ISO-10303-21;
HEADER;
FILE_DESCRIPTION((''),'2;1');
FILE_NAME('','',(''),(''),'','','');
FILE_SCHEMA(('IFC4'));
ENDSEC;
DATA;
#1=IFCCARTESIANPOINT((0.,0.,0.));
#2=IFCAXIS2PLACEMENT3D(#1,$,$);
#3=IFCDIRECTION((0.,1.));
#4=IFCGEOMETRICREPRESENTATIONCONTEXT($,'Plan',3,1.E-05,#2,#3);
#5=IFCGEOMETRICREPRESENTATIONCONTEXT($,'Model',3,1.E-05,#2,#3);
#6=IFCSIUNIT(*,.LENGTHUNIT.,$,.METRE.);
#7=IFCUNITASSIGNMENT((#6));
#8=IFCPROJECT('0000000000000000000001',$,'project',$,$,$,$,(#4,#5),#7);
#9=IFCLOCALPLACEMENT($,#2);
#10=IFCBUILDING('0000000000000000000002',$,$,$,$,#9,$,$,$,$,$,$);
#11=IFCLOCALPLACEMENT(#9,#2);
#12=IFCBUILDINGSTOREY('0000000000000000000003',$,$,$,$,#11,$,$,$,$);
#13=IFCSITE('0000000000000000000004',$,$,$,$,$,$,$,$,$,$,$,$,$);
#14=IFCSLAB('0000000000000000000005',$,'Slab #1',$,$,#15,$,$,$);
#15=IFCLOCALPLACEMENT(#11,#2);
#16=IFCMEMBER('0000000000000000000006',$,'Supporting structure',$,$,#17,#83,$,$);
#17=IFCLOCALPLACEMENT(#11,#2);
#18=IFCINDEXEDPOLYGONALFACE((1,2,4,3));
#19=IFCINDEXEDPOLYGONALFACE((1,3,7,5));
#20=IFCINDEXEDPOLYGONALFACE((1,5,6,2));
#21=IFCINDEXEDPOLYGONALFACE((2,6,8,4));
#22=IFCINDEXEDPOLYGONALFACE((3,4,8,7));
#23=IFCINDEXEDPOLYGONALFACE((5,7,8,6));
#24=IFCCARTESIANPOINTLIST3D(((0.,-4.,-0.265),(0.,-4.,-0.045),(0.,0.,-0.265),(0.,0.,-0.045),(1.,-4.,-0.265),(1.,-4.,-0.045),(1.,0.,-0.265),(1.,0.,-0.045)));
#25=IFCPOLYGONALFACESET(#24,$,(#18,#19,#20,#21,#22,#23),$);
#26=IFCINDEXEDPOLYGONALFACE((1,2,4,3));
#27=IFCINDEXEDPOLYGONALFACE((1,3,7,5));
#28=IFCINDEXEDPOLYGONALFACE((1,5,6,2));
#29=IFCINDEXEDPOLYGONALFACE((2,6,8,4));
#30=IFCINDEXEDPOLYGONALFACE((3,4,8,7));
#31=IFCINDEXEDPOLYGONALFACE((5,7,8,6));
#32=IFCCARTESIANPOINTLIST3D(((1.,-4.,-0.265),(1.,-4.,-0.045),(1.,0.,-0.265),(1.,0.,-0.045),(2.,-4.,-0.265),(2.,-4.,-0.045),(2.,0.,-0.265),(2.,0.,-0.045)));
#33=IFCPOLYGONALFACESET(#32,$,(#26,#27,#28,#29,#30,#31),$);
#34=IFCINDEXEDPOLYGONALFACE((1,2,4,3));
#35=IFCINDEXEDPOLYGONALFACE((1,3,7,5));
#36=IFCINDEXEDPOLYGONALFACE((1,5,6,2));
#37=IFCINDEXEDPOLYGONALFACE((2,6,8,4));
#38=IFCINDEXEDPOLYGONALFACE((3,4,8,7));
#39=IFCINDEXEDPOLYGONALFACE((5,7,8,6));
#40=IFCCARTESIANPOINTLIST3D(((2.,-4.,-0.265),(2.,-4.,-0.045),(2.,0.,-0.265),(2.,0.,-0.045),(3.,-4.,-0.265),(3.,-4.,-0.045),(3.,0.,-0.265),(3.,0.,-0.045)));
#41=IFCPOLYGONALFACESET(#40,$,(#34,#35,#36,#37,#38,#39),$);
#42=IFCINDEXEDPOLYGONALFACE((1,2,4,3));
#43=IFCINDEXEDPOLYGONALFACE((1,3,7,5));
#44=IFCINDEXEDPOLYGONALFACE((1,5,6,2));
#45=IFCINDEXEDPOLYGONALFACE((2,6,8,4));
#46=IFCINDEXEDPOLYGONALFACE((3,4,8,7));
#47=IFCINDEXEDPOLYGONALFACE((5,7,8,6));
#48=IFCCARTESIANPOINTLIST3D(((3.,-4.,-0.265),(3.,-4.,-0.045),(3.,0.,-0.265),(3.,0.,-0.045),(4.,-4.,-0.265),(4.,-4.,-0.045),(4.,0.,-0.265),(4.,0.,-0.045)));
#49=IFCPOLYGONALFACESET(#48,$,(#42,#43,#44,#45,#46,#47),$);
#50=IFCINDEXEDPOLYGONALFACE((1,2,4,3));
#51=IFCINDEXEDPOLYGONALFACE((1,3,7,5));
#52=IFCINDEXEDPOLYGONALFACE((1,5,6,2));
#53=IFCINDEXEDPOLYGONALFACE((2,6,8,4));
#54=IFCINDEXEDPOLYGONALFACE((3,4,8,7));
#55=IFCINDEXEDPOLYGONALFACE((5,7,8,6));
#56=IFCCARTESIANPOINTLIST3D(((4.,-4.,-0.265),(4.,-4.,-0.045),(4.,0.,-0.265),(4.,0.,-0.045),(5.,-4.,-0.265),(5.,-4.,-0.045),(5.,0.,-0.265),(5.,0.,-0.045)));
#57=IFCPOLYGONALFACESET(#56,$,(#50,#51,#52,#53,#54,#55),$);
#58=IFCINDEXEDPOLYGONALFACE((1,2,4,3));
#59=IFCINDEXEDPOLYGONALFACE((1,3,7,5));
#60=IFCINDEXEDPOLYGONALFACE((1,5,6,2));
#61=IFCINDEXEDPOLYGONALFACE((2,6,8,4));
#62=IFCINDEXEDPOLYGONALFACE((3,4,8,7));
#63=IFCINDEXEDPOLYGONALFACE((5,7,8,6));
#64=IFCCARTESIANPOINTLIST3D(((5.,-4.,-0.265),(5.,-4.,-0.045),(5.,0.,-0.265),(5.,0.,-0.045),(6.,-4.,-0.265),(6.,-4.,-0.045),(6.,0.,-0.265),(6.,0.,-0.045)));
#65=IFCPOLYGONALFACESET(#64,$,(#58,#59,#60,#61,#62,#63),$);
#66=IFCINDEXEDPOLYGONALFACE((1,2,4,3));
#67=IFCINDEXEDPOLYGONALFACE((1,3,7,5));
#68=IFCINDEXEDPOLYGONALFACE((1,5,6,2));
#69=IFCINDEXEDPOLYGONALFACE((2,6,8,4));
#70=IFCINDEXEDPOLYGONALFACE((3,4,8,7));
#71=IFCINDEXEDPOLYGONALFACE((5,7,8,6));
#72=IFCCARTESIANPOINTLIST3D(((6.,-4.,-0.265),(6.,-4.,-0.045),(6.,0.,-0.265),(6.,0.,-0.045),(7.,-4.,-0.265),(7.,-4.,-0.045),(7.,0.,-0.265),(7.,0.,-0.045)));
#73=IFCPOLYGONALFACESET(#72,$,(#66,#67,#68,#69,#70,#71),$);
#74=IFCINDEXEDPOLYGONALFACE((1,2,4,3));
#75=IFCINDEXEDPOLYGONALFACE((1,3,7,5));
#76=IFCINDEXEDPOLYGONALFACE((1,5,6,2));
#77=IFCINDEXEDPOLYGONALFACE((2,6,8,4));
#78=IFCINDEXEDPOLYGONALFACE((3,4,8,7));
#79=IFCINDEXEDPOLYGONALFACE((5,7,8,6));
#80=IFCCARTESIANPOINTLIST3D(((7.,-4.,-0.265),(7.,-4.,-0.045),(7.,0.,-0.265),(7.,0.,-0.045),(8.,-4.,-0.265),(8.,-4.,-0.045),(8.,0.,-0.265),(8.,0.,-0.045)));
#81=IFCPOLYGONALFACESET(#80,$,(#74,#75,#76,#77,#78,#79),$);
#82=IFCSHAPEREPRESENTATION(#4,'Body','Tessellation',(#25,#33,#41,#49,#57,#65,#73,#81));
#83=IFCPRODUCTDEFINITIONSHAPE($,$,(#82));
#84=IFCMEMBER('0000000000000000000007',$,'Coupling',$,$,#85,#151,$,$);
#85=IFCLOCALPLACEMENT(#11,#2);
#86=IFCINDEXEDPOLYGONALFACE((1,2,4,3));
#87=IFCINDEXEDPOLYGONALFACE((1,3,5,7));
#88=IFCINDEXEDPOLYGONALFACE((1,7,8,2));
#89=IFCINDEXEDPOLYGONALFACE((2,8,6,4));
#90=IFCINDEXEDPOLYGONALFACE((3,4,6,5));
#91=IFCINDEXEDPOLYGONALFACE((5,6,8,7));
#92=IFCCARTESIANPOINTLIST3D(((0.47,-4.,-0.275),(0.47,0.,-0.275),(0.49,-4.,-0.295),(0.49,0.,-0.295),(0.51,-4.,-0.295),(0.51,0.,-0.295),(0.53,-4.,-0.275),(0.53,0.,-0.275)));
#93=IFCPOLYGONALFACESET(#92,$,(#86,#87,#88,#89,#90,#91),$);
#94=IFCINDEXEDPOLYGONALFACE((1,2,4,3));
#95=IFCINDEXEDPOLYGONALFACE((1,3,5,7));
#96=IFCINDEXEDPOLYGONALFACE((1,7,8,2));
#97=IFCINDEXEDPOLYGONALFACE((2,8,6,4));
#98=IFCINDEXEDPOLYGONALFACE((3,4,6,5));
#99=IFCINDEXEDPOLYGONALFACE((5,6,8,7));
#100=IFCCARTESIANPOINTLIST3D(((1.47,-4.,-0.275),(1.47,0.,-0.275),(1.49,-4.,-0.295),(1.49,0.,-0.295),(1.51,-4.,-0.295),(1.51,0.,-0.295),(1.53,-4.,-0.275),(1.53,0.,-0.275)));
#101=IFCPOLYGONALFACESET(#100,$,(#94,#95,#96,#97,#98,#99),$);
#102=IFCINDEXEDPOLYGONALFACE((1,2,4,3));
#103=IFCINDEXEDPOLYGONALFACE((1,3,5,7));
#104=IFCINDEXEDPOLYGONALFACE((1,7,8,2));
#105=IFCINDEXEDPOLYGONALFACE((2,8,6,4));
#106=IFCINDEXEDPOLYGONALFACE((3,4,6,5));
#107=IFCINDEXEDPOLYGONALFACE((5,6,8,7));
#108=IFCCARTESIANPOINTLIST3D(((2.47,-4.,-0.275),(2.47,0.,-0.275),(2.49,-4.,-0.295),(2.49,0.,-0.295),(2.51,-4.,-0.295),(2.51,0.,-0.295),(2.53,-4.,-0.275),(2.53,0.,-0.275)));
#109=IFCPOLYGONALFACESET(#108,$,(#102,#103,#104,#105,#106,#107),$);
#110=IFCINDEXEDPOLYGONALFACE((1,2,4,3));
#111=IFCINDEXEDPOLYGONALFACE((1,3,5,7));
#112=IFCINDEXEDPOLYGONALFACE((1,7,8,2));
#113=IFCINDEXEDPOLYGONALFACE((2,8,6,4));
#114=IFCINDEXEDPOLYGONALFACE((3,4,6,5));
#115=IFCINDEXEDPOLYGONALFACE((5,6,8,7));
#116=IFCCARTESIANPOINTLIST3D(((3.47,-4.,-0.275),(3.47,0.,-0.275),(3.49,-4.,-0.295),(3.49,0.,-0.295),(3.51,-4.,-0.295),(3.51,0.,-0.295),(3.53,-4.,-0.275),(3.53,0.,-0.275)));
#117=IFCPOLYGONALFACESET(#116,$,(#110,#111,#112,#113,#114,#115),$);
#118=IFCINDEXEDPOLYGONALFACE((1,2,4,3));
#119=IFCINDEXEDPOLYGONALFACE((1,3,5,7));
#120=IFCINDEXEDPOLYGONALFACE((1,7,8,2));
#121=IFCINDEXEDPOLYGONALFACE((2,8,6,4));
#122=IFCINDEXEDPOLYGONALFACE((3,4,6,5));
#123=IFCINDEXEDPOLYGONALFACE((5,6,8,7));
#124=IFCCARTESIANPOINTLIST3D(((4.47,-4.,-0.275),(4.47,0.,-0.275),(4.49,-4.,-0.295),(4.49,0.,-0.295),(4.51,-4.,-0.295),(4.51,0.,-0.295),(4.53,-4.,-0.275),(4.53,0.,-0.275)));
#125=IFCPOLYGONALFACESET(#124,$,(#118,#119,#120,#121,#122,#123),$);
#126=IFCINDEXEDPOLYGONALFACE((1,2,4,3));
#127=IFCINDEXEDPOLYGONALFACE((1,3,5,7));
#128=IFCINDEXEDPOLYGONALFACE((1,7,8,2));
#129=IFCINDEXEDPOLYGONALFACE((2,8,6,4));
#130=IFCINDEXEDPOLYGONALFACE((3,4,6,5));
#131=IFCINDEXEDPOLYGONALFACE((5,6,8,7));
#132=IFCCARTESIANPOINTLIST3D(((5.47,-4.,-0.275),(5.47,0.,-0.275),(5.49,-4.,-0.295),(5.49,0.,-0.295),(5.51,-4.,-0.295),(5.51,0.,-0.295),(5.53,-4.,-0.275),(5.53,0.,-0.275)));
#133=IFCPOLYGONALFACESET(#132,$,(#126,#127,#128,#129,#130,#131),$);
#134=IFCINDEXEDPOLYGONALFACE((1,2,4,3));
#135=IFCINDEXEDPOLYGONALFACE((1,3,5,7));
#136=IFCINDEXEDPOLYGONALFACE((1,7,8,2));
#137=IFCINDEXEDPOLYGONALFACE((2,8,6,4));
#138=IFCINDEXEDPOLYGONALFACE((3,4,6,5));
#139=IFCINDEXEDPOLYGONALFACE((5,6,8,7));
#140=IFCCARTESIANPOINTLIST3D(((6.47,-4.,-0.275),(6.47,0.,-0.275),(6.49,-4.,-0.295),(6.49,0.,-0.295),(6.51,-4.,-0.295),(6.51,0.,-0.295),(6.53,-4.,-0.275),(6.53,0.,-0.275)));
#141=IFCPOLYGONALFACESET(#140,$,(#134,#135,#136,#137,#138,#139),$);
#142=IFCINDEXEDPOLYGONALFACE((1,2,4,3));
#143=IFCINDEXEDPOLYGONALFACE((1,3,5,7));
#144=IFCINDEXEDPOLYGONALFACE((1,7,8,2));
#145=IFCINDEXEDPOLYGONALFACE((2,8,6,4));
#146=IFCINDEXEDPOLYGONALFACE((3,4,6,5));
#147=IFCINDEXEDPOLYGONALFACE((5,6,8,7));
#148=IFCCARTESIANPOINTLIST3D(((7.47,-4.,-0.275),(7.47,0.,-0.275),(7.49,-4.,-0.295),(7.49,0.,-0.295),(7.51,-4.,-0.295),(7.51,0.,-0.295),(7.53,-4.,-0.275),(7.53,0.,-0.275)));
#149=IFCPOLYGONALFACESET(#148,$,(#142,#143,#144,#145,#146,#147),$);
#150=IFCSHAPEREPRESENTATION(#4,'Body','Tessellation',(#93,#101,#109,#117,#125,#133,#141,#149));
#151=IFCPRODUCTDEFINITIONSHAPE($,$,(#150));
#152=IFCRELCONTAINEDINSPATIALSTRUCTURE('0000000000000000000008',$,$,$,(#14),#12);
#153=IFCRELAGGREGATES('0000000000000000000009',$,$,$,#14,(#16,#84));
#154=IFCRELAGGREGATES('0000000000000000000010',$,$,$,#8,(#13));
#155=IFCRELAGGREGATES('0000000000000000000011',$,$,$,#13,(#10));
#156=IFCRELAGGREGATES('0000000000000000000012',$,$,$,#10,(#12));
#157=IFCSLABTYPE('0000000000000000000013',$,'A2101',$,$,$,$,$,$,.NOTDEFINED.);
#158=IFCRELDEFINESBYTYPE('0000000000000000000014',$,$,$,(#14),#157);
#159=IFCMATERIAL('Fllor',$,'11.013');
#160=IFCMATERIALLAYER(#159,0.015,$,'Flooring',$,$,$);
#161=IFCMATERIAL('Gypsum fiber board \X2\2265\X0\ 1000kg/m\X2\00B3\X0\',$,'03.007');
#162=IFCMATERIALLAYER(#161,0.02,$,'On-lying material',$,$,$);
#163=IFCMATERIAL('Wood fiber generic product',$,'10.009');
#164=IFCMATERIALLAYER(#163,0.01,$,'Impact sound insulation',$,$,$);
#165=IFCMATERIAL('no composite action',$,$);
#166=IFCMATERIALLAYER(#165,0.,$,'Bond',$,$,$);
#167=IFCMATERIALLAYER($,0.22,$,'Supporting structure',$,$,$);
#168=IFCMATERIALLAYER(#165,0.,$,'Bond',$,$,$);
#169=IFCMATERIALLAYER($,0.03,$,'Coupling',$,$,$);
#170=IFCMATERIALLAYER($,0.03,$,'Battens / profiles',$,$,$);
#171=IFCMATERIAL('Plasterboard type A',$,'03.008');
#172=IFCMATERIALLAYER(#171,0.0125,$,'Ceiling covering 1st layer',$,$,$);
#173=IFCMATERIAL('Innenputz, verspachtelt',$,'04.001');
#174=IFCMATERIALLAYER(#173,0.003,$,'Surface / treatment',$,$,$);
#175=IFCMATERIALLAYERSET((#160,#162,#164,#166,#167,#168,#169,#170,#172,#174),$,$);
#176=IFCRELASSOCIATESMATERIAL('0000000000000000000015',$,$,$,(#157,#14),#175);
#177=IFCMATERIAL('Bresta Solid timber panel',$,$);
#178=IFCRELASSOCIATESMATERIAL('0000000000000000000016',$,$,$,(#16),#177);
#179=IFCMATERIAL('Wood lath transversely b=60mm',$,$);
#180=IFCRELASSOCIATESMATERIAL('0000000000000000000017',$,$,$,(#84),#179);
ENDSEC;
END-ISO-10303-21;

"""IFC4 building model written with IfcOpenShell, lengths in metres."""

from ifc_helpers import new_model, si_unit, direction, frame, frame_2d, origin, place, context, project, spatial, polyline, rectangle, outline, extrude, material, layer, layer_set, type_object, element, aggregate, save


model = new_model("IFC4")

# Units and contexts
plan_context = context("Plan", 3, precision=1e-05, world=origin(), true_north=direction((0.0, 1.0)))
model_context = context("Model", 3, precision=1e-05, world=origin(), true_north=direction((0.0, 1.0)))
ifc_project = project(units=[si_unit("LENGTHUNIT", "METRE")], contexts=[plan_context, model_context])

# Site, building, storey
site = spatial("IfcSite", under=ifc_project)
building_placement = place(None, origin())
building = spatial("IfcBuilding", under=site, at=building_placement)
storey_placement = place(building_placement, origin())
storey = spatial("IfcBuildingStorey", under=building, at=storey_placement)

# Slab, members
ifc_material_1 = material(Name="Fllor", Category="11.013")
ifc_layer_1 = layer(ifc_material_1, 0.015, Name="Flooring")
ifc_material_2 = material(Name="Gypsum fiber board ≥ 1000kg/m³", Category="03.007")
ifc_layer_2 = layer(ifc_material_2, 0.02, Name="On-lying material")
ifc_material_3 = material(Name="Wood fiber generic product", Category="10.009")
ifc_layer_3 = layer(ifc_material_3, 0.01, Name="Impact sound insulation")
ifc_material_4 = material(Name="no composite action")
ifc_layer_4 = layer(ifc_material_4, 0.0, Name="Bond")
ifc_layer_5 = layer(None, 0.22, Name="Supporting structure")
ifc_layer_6 = layer(ifc_material_4, 0.0, Name="Bond")
ifc_layer_7 = layer(None, 0.03, Name="Coupling")
ifc_layer_8 = layer(None, 0.03, Name="Battens / profiles")
ifc_material_5 = material(Name="Plasterboard type A", Category="03.008")
ifc_layer_9 = layer(ifc_material_5, 0.0125, Name="Ceiling covering 1st layer")
ifc_material_6 = material(Name="Innenputz, verspachtelt", Category="04.001")
ifc_layer_10 = layer(ifc_material_6, 0.003, Name="Surface / treatment")
ifc_layer_set = layer_set([ifc_layer_1, ifc_layer_2, ifc_layer_3, ifc_layer_4, ifc_layer_5, ifc_layer_6, ifc_layer_7, ifc_layer_8, ifc_layer_9, ifc_layer_10])
slab_type = type_object("IfcSlabType", Name="A2101", PredefinedType="NOTDEFINED", material=ifc_layer_set)
slab_placement = place(None, frame((0.0, 0.0, 0.0), z_axis=(0.0, 0.0, -1.0), x_axis=(1.0, 0.0, 0.0)))
slab = element("IfcSlab", 1, at=slab_placement, inside=storey, type_object=slab_type, material=ifc_layer_set, Name="Slab #1")
ifc_material_7 = material(Name="Bresta Solid timber panel")
member_1_placement = place(slab_placement, origin())
member_1 = element("IfcMember", 2, at=member_1_placement, material=ifc_material_7, Name="Supporting structure", context=plan_context, shape_type="SweptSolid", body=[
    extrude(rectangle(XDim=1.0, YDim=0.22, at=frame_2d((0.5, 0.11), x_axis=(1.0, 0.0))), frame((0.0, 4.0, 0.045), z_axis=(0.0, -1.0, 0.0), x_axis=(1.0, 0.0, 0.0)), (0.0, 0.0, 1.0), 4.0),
    extrude(rectangle(XDim=1.0, YDim=0.22, at=frame_2d((0.5, 0.11), x_axis=(1.0, 0.0))), frame((1.0, 4.0, 0.045), z_axis=(0.0, -1.0, 0.0), x_axis=(1.0, 0.0, 0.0)), (0.0, 0.0, 1.0), 4.0),
    extrude(rectangle(XDim=1.0, YDim=0.22, at=frame_2d((0.5, 0.11), x_axis=(1.0, 0.0))), frame((2.0, 4.0, 0.045), z_axis=(0.0, -1.0, 0.0), x_axis=(1.0, 0.0, 0.0)), (0.0, 0.0, 1.0), 4.0),
    extrude(rectangle(XDim=1.0, YDim=0.22, at=frame_2d((0.5, 0.11), x_axis=(1.0, 0.0))), frame((3.0, 4.0, 0.045), z_axis=(0.0, -1.0, 0.0), x_axis=(1.0, 0.0, 0.0)), (0.0, 0.0, 1.0), 4.0),
    extrude(rectangle(XDim=1.0, YDim=0.22, at=frame_2d((0.5, 0.11), x_axis=(1.0, 0.0))), frame((4.0, 4.0, 0.045), z_axis=(0.0, -1.0, 0.0), x_axis=(1.0, 0.0, 0.0)), (0.0, 0.0, 1.0), 4.0),
    extrude(rectangle(XDim=1.0, YDim=0.22, at=frame_2d((0.5, 0.11), x_axis=(1.0, 0.0))), frame((5.0, 4.0, 0.045), z_axis=(0.0, -1.0, 0.0), x_axis=(1.0, 0.0, 0.0)), (0.0, 0.0, 1.0), 4.0),
    extrude(rectangle(XDim=1.0, YDim=0.22, at=frame_2d((0.5, 0.11), x_axis=(1.0, 0.0))), frame((6.0, 4.0, 0.045), z_axis=(0.0, -1.0, 0.0), x_axis=(1.0, 0.0, 0.0)), (0.0, 0.0, 1.0), 4.0),
    extrude(rectangle(XDim=1.0, YDim=0.22, at=frame_2d((0.5, 0.11), x_axis=(1.0, 0.0))), frame((7.0, 4.0, 0.045), z_axis=(0.0, -1.0, 0.0), x_axis=(1.0, 0.0, 0.0)), (0.0, 0.0, 1.0), 4.0),
])
ifc_material_8 = material(Name="Wood lath transversely b=60mm")
member_2_placement = place(slab_placement, origin())
member_2 = element("IfcMember", 3, at=member_2_placement, material=ifc_material_8, Name="Coupling", context=plan_context, shape_type="SweptSolid", body=[
    extrude(outline(polyline([(0.0, 0.0), (0.06, 0.0), (0.04, 0.02), (0.02, 0.02), (0.0, 0.0)])), frame((0.47, 4.0, 0.275), z_axis=(0.0, -1.0, 0.0), x_axis=(1.0, 0.0, 0.0)), (0.0, 0.0, 1.0), 4.0),
    extrude(outline(polyline([(0.0, 0.0), (0.06, 0.0), (0.04, 0.02), (0.02, 0.02), (0.0, 0.0)])), frame((1.47, 4.0, 0.275), z_axis=(0.0, -1.0, 0.0), x_axis=(1.0, 0.0, 0.0)), (0.0, 0.0, 1.0), 4.0),
    extrude(outline(polyline([(0.0, 0.0), (0.06, 0.0), (0.04, 0.02), (0.02, 0.02), (0.0, 0.0)])), frame((2.47, 4.0, 0.275), z_axis=(0.0, -1.0, 0.0), x_axis=(1.0, 0.0, 0.0)), (0.0, 0.0, 1.0), 4.0),
    extrude(outline(polyline([(0.0, 0.0), (0.06, 0.0), (0.04, 0.02), (0.02, 0.02), (0.0, 0.0)])), frame((3.47, 4.0, 0.275), z_axis=(0.0, -1.0, 0.0), x_axis=(1.0, 0.0, 0.0)), (0.0, 0.0, 1.0), 4.0),
    extrude(outline(polyline([(0.0, 0.0), (0.06, 0.0), (0.04, 0.02), (0.02, 0.02), (0.0, 0.0)])), frame((4.47, 4.0, 0.275), z_axis=(0.0, -1.0, 0.0), x_axis=(1.0, 0.0, 0.0)), (0.0, 0.0, 1.0), 4.0),
    extrude(outline(polyline([(0.0, 0.0), (0.06, 0.0), (0.04, 0.02), (0.02, 0.02), (0.0, 0.0)])), frame((5.47, 4.0, 0.275), z_axis=(0.0, -1.0, 0.0), x_axis=(1.0, 0.0, 0.0)), (0.0, 0.0, 1.0), 4.0),
    extrude(outline(polyline([(0.0, 0.0), (0.06, 0.0), (0.04, 0.02), (0.02, 0.02), (0.0, 0.0)])), frame((6.47, 4.0, 0.275), z_axis=(0.0, -1.0, 0.0), x_axis=(1.0, 0.0, 0.0)), (0.0, 0.0, 1.0), 4.0),
    extrude(outline(polyline([(0.0, 0.0), (0.06, 0.0), (0.04, 0.02), (0.02, 0.02), (0.0, 0.0)])), frame((7.47, 4.0, 0.275), z_axis=(0.0, -1.0, 0.0), x_axis=(1.0, 0.0, 0.0)), (0.0, 0.0, 1.0), 4.0),
])
aggregate(slab, [member_1, member_2])

save(model, "model.ifc")
